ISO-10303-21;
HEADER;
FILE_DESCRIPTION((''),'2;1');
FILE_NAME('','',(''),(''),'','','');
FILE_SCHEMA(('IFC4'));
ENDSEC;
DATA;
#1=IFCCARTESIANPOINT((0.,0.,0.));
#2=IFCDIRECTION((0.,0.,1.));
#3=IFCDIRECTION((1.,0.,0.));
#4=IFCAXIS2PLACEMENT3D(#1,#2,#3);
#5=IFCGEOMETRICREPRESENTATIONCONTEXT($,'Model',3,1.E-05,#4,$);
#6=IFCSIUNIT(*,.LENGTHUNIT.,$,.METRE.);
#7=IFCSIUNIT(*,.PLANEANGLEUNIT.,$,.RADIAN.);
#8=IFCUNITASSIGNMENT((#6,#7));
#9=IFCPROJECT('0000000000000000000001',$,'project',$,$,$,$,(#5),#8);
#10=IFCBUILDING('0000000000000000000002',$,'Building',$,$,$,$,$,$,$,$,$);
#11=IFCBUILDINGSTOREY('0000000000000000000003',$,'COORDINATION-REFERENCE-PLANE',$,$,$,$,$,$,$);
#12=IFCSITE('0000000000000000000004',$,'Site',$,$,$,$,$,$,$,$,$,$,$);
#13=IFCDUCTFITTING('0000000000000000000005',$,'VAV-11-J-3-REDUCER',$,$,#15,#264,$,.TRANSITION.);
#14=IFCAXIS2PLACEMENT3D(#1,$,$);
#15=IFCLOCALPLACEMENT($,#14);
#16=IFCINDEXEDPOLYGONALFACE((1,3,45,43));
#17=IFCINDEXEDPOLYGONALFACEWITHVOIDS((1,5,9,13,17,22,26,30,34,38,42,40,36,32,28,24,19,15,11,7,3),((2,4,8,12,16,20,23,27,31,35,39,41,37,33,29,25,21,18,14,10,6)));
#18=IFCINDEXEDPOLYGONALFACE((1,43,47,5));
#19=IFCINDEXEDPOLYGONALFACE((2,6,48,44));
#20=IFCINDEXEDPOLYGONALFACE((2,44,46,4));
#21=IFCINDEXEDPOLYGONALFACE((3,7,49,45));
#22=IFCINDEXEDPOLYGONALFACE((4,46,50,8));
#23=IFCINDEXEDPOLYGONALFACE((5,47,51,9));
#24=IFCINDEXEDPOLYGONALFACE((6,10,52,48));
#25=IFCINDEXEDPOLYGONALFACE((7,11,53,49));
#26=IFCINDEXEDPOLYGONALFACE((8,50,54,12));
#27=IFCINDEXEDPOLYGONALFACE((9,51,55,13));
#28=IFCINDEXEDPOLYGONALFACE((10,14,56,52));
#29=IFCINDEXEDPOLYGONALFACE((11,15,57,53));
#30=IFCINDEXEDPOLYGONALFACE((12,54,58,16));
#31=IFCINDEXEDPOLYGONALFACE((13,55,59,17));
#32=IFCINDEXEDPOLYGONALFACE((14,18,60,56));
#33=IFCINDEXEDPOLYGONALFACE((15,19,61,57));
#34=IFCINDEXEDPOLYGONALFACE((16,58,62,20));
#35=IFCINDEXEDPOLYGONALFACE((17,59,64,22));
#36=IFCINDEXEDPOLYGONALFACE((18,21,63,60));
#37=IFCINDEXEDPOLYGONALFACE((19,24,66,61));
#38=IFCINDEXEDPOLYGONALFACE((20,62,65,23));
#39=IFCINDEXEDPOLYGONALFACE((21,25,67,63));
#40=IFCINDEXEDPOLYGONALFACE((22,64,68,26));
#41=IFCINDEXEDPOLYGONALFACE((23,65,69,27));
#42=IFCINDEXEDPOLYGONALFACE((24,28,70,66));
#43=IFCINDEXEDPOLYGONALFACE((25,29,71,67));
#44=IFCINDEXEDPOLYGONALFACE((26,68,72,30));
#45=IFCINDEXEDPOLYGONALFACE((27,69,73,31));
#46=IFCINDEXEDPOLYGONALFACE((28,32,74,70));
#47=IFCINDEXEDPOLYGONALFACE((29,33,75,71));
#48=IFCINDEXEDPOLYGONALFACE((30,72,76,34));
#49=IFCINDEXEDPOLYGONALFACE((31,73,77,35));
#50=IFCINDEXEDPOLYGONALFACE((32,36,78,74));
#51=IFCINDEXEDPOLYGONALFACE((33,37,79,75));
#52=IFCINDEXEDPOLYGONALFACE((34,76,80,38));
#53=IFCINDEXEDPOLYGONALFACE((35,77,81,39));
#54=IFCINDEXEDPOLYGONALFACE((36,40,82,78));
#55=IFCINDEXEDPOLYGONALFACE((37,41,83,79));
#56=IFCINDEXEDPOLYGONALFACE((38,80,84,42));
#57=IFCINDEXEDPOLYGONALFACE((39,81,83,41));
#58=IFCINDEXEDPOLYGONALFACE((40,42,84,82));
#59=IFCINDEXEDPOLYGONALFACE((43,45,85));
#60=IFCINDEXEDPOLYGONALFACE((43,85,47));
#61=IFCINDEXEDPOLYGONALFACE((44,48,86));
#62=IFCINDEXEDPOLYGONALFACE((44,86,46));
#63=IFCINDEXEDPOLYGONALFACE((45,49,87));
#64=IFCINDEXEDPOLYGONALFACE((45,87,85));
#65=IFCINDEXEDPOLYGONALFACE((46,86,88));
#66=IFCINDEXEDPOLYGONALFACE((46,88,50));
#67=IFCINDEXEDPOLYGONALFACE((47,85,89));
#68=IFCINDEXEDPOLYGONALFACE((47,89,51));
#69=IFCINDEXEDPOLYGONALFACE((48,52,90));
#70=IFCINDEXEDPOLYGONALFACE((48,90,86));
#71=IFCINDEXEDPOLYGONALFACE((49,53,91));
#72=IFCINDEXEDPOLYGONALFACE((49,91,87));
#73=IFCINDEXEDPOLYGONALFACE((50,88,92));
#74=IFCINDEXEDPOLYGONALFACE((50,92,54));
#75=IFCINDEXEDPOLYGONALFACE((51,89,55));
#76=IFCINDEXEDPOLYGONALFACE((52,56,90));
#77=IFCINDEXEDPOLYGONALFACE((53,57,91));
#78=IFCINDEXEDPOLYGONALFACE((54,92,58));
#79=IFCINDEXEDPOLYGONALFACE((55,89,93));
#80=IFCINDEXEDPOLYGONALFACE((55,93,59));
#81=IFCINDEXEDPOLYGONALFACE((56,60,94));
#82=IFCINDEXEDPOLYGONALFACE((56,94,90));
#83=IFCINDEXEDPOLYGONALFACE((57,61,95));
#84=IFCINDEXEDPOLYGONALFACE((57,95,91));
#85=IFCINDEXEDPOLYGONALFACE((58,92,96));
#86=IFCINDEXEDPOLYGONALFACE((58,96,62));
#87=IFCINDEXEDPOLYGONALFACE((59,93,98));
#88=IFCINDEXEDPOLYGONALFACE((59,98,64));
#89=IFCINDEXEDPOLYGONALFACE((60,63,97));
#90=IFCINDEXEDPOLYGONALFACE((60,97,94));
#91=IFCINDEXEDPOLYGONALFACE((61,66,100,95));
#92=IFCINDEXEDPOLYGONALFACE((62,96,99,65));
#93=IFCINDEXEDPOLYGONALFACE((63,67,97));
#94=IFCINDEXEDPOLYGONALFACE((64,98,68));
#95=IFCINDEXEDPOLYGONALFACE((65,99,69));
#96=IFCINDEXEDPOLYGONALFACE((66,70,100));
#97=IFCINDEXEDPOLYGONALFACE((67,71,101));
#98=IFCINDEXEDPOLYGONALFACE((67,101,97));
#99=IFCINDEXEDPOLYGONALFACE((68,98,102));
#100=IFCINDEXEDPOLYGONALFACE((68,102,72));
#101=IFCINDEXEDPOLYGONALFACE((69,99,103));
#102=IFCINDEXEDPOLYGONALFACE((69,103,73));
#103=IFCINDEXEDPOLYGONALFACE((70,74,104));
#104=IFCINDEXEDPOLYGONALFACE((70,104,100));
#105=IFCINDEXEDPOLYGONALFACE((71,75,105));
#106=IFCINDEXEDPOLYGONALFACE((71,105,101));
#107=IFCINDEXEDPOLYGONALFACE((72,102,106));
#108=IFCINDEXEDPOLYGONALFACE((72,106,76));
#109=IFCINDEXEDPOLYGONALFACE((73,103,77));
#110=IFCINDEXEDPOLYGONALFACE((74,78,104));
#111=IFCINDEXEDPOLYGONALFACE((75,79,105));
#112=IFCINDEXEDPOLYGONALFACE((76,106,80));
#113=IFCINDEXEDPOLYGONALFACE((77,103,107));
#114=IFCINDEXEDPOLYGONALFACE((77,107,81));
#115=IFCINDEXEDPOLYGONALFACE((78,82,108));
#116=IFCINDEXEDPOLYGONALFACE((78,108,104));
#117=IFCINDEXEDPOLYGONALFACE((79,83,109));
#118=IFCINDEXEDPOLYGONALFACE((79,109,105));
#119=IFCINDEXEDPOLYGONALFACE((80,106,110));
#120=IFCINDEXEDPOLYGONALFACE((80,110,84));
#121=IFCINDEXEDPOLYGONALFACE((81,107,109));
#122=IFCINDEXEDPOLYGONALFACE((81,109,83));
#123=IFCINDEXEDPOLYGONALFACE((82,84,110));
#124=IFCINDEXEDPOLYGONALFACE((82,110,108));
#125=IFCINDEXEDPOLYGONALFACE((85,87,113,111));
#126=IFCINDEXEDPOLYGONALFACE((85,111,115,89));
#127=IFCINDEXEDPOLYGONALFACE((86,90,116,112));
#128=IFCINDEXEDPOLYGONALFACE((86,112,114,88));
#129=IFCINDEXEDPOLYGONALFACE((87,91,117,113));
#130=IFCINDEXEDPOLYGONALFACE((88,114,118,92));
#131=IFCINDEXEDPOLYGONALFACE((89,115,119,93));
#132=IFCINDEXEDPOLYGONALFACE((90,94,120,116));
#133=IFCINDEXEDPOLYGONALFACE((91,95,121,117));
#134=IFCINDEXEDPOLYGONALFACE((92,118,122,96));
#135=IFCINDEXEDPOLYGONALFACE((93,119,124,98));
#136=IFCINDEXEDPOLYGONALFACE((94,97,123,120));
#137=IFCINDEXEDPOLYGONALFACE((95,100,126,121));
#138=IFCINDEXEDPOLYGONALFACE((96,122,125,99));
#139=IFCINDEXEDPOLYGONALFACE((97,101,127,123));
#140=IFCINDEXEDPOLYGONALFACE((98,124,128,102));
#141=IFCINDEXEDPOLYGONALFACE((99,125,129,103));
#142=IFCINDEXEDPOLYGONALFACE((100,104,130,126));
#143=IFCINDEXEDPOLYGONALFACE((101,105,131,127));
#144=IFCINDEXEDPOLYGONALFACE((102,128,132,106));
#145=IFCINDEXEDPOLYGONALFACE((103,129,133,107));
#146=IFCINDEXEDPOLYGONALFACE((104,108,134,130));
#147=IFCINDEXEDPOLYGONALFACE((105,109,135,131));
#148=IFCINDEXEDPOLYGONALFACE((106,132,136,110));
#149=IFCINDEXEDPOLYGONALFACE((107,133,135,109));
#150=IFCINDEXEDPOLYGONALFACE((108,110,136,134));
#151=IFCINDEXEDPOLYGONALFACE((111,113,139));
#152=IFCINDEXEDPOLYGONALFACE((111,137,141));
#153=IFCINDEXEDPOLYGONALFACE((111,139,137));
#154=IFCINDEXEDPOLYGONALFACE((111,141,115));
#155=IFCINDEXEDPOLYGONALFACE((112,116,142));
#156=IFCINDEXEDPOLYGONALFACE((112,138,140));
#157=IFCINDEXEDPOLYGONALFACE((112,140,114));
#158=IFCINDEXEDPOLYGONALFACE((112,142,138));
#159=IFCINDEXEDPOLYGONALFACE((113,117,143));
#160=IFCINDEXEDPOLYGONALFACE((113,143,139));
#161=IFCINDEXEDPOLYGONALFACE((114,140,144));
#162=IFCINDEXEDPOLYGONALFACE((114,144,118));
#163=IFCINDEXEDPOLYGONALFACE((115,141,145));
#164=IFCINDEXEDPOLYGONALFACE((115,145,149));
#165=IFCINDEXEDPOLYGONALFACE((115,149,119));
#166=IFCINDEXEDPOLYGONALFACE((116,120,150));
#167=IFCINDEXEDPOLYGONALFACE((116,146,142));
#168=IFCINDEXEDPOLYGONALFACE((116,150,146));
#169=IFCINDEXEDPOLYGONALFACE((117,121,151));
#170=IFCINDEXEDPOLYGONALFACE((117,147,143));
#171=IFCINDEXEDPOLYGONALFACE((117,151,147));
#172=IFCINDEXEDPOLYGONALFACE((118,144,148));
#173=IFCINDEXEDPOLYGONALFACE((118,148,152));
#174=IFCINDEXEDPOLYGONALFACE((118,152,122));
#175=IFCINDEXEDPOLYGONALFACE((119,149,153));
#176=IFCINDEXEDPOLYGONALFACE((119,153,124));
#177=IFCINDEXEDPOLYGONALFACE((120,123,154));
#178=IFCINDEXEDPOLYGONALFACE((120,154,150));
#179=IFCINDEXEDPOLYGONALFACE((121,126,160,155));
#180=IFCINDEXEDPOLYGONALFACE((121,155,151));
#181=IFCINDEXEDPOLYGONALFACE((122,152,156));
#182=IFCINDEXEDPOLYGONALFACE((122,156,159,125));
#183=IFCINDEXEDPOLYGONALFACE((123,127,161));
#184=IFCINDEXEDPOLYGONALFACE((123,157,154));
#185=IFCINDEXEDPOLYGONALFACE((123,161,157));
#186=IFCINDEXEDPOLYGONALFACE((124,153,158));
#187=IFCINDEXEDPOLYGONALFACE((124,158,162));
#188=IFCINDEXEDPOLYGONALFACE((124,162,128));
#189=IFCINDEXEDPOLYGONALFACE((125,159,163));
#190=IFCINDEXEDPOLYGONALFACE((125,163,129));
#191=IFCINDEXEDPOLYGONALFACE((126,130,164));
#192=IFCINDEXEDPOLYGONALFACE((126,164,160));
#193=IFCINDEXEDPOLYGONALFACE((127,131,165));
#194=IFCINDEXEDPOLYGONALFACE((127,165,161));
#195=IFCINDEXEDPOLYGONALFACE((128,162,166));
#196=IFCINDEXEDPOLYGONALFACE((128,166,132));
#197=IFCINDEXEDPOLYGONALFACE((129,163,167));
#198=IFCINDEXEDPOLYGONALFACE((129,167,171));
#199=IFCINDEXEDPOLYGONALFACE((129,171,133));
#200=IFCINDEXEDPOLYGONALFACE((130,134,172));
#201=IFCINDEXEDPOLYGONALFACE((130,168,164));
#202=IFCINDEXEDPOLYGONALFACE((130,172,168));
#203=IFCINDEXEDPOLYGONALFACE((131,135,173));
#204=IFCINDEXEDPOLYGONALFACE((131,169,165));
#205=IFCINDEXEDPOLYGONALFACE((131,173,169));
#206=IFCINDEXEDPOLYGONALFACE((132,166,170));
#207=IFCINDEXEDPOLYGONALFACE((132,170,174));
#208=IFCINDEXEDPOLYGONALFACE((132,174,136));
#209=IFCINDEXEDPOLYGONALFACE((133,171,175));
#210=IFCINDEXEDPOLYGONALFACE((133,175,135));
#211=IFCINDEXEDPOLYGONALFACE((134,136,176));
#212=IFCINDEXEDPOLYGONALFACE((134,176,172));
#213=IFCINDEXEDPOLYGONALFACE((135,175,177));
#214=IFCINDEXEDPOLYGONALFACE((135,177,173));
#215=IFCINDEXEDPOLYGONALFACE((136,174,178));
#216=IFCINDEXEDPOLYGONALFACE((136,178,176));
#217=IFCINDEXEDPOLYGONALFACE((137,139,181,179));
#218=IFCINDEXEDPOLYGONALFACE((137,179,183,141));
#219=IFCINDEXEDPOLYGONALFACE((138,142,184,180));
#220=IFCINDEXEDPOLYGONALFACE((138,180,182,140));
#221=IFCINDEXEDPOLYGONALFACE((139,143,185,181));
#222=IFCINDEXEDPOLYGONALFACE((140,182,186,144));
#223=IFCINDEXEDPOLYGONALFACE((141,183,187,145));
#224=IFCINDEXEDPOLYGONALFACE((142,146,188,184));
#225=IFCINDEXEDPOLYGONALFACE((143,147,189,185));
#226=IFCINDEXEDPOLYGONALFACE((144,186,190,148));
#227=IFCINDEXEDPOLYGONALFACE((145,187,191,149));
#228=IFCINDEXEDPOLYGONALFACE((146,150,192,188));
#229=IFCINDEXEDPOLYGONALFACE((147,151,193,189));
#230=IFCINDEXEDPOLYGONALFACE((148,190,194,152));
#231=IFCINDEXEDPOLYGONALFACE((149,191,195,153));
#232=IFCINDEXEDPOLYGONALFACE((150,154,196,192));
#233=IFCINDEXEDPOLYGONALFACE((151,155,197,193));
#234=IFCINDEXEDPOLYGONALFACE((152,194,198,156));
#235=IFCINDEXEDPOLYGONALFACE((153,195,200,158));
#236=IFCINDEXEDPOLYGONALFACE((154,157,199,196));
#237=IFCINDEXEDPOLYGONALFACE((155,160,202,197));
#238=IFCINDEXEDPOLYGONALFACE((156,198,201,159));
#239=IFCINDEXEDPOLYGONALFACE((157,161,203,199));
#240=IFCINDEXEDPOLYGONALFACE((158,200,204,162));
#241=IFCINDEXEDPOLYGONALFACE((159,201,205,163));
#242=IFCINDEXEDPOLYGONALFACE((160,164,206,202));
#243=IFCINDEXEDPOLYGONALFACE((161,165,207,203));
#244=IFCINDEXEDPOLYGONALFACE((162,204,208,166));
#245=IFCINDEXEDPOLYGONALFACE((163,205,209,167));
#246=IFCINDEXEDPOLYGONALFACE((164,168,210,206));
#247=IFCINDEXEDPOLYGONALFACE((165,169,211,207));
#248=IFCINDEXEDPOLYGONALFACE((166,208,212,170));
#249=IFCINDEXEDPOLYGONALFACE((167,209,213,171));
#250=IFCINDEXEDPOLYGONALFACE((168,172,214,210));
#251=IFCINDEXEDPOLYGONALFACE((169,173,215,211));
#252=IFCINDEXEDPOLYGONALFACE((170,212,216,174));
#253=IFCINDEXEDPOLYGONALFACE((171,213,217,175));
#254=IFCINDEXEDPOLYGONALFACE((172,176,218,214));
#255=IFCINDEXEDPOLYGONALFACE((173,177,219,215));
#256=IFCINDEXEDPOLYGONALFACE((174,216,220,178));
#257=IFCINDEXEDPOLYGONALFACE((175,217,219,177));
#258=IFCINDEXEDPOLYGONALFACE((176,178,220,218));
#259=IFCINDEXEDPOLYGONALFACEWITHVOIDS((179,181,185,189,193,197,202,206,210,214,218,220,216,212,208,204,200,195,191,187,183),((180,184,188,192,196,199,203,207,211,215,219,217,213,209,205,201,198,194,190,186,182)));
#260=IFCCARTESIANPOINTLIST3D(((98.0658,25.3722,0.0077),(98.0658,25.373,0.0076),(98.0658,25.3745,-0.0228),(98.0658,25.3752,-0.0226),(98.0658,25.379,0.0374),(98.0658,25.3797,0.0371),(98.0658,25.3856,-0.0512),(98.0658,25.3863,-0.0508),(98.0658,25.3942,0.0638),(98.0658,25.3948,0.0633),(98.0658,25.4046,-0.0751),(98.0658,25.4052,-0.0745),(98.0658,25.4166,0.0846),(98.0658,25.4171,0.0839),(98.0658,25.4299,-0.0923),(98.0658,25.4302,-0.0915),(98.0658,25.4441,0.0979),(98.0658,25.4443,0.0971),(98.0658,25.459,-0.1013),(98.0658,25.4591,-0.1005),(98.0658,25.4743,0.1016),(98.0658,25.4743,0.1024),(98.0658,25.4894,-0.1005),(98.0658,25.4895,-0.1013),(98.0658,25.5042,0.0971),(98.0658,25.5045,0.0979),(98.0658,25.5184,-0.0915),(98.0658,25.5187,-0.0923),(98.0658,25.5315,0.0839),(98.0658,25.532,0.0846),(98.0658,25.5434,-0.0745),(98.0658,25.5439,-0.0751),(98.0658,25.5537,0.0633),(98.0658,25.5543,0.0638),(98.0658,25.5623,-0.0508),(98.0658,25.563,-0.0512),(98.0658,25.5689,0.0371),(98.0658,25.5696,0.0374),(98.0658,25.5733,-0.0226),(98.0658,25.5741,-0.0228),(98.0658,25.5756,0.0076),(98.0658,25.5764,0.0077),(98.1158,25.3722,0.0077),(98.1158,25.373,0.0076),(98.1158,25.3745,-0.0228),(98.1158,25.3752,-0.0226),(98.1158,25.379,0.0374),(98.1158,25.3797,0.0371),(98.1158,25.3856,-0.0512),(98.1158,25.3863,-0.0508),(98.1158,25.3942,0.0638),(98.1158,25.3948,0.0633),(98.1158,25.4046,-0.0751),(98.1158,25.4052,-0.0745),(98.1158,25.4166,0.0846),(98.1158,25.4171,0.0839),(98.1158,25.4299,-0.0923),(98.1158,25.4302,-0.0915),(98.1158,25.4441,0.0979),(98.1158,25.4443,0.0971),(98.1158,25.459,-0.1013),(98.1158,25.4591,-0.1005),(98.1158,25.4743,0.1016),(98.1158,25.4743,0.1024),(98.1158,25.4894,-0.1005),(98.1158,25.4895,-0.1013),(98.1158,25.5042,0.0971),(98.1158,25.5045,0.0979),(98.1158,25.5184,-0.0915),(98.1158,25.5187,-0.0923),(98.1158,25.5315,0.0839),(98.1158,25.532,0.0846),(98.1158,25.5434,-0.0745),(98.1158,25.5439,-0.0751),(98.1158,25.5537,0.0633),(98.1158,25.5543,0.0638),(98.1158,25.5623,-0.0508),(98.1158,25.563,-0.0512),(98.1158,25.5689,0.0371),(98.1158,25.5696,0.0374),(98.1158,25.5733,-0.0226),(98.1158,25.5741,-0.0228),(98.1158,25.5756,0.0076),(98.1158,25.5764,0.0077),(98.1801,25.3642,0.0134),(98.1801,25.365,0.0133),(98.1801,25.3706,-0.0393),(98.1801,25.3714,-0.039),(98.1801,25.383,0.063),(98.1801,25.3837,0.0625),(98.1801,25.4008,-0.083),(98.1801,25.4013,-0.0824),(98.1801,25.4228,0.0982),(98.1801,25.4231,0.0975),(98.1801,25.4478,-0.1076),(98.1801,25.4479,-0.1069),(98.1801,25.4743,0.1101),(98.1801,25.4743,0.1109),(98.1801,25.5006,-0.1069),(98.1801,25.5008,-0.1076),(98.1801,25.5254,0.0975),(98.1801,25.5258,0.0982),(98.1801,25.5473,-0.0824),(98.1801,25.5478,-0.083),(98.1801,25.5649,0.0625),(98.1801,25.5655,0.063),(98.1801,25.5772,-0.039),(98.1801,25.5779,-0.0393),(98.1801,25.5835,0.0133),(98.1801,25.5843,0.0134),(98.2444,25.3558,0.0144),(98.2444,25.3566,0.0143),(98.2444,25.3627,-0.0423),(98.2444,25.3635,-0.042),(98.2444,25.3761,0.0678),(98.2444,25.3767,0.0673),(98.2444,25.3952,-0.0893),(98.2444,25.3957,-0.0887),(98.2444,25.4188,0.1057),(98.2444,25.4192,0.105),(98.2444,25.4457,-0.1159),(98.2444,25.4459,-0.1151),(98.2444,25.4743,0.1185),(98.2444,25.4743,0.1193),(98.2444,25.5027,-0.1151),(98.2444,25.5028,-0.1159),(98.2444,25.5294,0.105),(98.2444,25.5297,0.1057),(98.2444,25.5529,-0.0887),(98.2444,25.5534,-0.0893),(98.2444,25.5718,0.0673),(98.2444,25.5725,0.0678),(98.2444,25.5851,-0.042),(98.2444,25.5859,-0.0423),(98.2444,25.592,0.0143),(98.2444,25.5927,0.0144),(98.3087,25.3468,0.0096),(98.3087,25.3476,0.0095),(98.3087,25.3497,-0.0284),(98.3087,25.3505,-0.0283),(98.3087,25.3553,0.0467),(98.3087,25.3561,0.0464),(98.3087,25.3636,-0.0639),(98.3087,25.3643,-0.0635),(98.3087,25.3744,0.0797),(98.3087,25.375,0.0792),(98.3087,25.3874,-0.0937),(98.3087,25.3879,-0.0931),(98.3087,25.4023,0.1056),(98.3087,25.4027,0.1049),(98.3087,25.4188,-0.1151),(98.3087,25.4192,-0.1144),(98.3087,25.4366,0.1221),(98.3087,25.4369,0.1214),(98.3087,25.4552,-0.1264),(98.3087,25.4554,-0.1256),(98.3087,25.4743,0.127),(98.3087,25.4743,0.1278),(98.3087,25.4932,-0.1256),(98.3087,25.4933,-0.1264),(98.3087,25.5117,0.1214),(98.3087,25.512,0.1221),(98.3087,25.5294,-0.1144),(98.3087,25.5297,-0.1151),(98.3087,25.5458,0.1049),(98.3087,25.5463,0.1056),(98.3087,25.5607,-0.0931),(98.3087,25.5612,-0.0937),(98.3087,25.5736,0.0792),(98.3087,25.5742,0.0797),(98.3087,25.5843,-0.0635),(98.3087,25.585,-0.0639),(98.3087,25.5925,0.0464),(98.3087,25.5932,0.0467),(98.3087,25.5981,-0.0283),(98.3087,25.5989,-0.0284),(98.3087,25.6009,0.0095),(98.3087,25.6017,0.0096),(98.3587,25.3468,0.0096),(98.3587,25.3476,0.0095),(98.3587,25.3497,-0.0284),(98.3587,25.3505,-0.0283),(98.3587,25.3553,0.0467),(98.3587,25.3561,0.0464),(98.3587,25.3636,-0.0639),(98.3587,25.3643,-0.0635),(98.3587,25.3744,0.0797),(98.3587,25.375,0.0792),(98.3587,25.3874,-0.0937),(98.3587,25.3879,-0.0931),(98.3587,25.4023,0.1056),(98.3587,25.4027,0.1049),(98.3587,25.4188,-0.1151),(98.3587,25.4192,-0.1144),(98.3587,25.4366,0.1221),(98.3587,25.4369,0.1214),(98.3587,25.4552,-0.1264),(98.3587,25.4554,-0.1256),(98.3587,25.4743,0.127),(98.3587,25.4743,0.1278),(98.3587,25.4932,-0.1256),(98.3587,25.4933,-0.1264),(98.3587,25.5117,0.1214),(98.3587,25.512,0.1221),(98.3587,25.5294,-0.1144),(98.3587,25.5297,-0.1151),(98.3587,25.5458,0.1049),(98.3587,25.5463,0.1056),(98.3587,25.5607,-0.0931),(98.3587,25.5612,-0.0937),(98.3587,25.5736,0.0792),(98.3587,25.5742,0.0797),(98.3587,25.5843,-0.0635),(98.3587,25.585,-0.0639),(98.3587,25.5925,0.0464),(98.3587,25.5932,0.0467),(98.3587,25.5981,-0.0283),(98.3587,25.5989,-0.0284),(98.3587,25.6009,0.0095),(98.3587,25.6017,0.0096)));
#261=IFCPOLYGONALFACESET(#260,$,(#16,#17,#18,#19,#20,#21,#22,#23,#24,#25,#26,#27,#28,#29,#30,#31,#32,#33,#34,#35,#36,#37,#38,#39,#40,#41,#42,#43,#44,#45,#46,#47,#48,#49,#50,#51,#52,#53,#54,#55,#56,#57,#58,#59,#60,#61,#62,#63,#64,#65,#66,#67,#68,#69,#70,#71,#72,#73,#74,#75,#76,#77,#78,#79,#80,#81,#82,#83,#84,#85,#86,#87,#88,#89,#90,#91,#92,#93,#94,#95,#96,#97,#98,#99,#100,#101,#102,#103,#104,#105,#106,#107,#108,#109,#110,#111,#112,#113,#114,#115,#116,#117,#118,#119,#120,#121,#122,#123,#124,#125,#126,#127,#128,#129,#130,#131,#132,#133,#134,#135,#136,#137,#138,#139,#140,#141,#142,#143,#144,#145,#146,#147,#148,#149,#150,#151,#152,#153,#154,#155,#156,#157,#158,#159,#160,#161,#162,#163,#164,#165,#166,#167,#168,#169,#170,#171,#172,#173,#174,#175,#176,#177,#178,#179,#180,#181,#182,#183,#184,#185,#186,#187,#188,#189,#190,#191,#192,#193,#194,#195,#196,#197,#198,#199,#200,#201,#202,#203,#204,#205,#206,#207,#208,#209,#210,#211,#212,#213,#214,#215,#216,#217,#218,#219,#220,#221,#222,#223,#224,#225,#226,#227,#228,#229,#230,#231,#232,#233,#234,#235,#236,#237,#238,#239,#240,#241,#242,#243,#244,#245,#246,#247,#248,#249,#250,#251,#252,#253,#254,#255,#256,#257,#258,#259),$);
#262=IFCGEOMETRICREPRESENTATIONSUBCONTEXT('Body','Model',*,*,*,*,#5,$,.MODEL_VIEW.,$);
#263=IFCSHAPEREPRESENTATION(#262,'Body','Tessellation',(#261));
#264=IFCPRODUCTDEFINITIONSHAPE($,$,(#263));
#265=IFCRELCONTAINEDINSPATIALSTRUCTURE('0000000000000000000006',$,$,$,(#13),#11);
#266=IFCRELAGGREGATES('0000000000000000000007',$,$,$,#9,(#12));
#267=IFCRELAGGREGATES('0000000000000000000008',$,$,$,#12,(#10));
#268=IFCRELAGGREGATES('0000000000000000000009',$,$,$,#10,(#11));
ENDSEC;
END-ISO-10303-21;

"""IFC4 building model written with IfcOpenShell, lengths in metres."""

from ifc_helpers import new_model, entity, si_unit, frame, origin_with_axes, place, context, subcontext, project, spatial, element, save


model = new_model("IFC4")

# Units and contexts
model_context_1 = context("Model", 3, precision=1e-05, world=origin_with_axes())
body_context_1 = subcontext(model_context_1, "Body", "Model", "MODEL_VIEW")
ifc_project = project(units=[si_unit("LENGTHUNIT", "METRE"), si_unit("PLANEANGLEUNIT", "RADIAN")], contexts=[model_context_1])

# Site, building, storey
site = spatial("IfcSite", under=ifc_project, Name="Site")
building = spatial("IfcBuilding", under=site, Name="Building")
storey = spatial("IfcBuildingStorey", under=building, Name="COORDINATION-REFERENCE-PLANE")

# Duct fitting
for number, where, z_axis, x_axis, name in (
    (1, (98.3587, 25.4743, 0.0), (0.0, -1.0, 0.0), (0.0, 0.0, 1.0), "VAV-11-J-3-REDUCER"),
):
    element("IfcDuctFitting", number, at=place(None, frame(where, z_axis=z_axis, x_axis=x_axis)), inside=storey, Name=name, PredefinedType="TRANSITION", context=body_context_1, shape_type="SweptSolid", body=[
        entity("IfcRevolvedAreaSolid", entity("IfcArbitraryClosedProfileDef", "AREA", None, entity("IfcPolyline", [entity("IfcCartesianPoint", [0.1278, 0.0]), entity("IfcCartesianPoint", [0.1278, 0.05]), entity("IfcCartesianPoint", [0.1024, 0.2429]), entity("IfcCartesianPoint", [0.1024, 0.2929]), entity("IfcCartesianPoint", [0.1016, 0.2929]), entity("IfcCartesianPoint", [0.1016, 0.2429]), entity("IfcCartesianPoint", [0.127, 0.05]), entity("IfcCartesianPoint", [0.127, 0.0]), entity("IfcCartesianPoint", [0.1278, 0.0])])), entity("IfcAxis2Placement3D", entity("IfcCartesianPoint", [0.0, 0.0, 0.0])), entity("IfcAxis1Placement", entity("IfcCartesianPoint", [0.0, 0.0, 0.0]), entity("IfcDirection", [0.0, 1.0, 0.0])), 6.283185),
    ])

save(model, "model.ifc")
